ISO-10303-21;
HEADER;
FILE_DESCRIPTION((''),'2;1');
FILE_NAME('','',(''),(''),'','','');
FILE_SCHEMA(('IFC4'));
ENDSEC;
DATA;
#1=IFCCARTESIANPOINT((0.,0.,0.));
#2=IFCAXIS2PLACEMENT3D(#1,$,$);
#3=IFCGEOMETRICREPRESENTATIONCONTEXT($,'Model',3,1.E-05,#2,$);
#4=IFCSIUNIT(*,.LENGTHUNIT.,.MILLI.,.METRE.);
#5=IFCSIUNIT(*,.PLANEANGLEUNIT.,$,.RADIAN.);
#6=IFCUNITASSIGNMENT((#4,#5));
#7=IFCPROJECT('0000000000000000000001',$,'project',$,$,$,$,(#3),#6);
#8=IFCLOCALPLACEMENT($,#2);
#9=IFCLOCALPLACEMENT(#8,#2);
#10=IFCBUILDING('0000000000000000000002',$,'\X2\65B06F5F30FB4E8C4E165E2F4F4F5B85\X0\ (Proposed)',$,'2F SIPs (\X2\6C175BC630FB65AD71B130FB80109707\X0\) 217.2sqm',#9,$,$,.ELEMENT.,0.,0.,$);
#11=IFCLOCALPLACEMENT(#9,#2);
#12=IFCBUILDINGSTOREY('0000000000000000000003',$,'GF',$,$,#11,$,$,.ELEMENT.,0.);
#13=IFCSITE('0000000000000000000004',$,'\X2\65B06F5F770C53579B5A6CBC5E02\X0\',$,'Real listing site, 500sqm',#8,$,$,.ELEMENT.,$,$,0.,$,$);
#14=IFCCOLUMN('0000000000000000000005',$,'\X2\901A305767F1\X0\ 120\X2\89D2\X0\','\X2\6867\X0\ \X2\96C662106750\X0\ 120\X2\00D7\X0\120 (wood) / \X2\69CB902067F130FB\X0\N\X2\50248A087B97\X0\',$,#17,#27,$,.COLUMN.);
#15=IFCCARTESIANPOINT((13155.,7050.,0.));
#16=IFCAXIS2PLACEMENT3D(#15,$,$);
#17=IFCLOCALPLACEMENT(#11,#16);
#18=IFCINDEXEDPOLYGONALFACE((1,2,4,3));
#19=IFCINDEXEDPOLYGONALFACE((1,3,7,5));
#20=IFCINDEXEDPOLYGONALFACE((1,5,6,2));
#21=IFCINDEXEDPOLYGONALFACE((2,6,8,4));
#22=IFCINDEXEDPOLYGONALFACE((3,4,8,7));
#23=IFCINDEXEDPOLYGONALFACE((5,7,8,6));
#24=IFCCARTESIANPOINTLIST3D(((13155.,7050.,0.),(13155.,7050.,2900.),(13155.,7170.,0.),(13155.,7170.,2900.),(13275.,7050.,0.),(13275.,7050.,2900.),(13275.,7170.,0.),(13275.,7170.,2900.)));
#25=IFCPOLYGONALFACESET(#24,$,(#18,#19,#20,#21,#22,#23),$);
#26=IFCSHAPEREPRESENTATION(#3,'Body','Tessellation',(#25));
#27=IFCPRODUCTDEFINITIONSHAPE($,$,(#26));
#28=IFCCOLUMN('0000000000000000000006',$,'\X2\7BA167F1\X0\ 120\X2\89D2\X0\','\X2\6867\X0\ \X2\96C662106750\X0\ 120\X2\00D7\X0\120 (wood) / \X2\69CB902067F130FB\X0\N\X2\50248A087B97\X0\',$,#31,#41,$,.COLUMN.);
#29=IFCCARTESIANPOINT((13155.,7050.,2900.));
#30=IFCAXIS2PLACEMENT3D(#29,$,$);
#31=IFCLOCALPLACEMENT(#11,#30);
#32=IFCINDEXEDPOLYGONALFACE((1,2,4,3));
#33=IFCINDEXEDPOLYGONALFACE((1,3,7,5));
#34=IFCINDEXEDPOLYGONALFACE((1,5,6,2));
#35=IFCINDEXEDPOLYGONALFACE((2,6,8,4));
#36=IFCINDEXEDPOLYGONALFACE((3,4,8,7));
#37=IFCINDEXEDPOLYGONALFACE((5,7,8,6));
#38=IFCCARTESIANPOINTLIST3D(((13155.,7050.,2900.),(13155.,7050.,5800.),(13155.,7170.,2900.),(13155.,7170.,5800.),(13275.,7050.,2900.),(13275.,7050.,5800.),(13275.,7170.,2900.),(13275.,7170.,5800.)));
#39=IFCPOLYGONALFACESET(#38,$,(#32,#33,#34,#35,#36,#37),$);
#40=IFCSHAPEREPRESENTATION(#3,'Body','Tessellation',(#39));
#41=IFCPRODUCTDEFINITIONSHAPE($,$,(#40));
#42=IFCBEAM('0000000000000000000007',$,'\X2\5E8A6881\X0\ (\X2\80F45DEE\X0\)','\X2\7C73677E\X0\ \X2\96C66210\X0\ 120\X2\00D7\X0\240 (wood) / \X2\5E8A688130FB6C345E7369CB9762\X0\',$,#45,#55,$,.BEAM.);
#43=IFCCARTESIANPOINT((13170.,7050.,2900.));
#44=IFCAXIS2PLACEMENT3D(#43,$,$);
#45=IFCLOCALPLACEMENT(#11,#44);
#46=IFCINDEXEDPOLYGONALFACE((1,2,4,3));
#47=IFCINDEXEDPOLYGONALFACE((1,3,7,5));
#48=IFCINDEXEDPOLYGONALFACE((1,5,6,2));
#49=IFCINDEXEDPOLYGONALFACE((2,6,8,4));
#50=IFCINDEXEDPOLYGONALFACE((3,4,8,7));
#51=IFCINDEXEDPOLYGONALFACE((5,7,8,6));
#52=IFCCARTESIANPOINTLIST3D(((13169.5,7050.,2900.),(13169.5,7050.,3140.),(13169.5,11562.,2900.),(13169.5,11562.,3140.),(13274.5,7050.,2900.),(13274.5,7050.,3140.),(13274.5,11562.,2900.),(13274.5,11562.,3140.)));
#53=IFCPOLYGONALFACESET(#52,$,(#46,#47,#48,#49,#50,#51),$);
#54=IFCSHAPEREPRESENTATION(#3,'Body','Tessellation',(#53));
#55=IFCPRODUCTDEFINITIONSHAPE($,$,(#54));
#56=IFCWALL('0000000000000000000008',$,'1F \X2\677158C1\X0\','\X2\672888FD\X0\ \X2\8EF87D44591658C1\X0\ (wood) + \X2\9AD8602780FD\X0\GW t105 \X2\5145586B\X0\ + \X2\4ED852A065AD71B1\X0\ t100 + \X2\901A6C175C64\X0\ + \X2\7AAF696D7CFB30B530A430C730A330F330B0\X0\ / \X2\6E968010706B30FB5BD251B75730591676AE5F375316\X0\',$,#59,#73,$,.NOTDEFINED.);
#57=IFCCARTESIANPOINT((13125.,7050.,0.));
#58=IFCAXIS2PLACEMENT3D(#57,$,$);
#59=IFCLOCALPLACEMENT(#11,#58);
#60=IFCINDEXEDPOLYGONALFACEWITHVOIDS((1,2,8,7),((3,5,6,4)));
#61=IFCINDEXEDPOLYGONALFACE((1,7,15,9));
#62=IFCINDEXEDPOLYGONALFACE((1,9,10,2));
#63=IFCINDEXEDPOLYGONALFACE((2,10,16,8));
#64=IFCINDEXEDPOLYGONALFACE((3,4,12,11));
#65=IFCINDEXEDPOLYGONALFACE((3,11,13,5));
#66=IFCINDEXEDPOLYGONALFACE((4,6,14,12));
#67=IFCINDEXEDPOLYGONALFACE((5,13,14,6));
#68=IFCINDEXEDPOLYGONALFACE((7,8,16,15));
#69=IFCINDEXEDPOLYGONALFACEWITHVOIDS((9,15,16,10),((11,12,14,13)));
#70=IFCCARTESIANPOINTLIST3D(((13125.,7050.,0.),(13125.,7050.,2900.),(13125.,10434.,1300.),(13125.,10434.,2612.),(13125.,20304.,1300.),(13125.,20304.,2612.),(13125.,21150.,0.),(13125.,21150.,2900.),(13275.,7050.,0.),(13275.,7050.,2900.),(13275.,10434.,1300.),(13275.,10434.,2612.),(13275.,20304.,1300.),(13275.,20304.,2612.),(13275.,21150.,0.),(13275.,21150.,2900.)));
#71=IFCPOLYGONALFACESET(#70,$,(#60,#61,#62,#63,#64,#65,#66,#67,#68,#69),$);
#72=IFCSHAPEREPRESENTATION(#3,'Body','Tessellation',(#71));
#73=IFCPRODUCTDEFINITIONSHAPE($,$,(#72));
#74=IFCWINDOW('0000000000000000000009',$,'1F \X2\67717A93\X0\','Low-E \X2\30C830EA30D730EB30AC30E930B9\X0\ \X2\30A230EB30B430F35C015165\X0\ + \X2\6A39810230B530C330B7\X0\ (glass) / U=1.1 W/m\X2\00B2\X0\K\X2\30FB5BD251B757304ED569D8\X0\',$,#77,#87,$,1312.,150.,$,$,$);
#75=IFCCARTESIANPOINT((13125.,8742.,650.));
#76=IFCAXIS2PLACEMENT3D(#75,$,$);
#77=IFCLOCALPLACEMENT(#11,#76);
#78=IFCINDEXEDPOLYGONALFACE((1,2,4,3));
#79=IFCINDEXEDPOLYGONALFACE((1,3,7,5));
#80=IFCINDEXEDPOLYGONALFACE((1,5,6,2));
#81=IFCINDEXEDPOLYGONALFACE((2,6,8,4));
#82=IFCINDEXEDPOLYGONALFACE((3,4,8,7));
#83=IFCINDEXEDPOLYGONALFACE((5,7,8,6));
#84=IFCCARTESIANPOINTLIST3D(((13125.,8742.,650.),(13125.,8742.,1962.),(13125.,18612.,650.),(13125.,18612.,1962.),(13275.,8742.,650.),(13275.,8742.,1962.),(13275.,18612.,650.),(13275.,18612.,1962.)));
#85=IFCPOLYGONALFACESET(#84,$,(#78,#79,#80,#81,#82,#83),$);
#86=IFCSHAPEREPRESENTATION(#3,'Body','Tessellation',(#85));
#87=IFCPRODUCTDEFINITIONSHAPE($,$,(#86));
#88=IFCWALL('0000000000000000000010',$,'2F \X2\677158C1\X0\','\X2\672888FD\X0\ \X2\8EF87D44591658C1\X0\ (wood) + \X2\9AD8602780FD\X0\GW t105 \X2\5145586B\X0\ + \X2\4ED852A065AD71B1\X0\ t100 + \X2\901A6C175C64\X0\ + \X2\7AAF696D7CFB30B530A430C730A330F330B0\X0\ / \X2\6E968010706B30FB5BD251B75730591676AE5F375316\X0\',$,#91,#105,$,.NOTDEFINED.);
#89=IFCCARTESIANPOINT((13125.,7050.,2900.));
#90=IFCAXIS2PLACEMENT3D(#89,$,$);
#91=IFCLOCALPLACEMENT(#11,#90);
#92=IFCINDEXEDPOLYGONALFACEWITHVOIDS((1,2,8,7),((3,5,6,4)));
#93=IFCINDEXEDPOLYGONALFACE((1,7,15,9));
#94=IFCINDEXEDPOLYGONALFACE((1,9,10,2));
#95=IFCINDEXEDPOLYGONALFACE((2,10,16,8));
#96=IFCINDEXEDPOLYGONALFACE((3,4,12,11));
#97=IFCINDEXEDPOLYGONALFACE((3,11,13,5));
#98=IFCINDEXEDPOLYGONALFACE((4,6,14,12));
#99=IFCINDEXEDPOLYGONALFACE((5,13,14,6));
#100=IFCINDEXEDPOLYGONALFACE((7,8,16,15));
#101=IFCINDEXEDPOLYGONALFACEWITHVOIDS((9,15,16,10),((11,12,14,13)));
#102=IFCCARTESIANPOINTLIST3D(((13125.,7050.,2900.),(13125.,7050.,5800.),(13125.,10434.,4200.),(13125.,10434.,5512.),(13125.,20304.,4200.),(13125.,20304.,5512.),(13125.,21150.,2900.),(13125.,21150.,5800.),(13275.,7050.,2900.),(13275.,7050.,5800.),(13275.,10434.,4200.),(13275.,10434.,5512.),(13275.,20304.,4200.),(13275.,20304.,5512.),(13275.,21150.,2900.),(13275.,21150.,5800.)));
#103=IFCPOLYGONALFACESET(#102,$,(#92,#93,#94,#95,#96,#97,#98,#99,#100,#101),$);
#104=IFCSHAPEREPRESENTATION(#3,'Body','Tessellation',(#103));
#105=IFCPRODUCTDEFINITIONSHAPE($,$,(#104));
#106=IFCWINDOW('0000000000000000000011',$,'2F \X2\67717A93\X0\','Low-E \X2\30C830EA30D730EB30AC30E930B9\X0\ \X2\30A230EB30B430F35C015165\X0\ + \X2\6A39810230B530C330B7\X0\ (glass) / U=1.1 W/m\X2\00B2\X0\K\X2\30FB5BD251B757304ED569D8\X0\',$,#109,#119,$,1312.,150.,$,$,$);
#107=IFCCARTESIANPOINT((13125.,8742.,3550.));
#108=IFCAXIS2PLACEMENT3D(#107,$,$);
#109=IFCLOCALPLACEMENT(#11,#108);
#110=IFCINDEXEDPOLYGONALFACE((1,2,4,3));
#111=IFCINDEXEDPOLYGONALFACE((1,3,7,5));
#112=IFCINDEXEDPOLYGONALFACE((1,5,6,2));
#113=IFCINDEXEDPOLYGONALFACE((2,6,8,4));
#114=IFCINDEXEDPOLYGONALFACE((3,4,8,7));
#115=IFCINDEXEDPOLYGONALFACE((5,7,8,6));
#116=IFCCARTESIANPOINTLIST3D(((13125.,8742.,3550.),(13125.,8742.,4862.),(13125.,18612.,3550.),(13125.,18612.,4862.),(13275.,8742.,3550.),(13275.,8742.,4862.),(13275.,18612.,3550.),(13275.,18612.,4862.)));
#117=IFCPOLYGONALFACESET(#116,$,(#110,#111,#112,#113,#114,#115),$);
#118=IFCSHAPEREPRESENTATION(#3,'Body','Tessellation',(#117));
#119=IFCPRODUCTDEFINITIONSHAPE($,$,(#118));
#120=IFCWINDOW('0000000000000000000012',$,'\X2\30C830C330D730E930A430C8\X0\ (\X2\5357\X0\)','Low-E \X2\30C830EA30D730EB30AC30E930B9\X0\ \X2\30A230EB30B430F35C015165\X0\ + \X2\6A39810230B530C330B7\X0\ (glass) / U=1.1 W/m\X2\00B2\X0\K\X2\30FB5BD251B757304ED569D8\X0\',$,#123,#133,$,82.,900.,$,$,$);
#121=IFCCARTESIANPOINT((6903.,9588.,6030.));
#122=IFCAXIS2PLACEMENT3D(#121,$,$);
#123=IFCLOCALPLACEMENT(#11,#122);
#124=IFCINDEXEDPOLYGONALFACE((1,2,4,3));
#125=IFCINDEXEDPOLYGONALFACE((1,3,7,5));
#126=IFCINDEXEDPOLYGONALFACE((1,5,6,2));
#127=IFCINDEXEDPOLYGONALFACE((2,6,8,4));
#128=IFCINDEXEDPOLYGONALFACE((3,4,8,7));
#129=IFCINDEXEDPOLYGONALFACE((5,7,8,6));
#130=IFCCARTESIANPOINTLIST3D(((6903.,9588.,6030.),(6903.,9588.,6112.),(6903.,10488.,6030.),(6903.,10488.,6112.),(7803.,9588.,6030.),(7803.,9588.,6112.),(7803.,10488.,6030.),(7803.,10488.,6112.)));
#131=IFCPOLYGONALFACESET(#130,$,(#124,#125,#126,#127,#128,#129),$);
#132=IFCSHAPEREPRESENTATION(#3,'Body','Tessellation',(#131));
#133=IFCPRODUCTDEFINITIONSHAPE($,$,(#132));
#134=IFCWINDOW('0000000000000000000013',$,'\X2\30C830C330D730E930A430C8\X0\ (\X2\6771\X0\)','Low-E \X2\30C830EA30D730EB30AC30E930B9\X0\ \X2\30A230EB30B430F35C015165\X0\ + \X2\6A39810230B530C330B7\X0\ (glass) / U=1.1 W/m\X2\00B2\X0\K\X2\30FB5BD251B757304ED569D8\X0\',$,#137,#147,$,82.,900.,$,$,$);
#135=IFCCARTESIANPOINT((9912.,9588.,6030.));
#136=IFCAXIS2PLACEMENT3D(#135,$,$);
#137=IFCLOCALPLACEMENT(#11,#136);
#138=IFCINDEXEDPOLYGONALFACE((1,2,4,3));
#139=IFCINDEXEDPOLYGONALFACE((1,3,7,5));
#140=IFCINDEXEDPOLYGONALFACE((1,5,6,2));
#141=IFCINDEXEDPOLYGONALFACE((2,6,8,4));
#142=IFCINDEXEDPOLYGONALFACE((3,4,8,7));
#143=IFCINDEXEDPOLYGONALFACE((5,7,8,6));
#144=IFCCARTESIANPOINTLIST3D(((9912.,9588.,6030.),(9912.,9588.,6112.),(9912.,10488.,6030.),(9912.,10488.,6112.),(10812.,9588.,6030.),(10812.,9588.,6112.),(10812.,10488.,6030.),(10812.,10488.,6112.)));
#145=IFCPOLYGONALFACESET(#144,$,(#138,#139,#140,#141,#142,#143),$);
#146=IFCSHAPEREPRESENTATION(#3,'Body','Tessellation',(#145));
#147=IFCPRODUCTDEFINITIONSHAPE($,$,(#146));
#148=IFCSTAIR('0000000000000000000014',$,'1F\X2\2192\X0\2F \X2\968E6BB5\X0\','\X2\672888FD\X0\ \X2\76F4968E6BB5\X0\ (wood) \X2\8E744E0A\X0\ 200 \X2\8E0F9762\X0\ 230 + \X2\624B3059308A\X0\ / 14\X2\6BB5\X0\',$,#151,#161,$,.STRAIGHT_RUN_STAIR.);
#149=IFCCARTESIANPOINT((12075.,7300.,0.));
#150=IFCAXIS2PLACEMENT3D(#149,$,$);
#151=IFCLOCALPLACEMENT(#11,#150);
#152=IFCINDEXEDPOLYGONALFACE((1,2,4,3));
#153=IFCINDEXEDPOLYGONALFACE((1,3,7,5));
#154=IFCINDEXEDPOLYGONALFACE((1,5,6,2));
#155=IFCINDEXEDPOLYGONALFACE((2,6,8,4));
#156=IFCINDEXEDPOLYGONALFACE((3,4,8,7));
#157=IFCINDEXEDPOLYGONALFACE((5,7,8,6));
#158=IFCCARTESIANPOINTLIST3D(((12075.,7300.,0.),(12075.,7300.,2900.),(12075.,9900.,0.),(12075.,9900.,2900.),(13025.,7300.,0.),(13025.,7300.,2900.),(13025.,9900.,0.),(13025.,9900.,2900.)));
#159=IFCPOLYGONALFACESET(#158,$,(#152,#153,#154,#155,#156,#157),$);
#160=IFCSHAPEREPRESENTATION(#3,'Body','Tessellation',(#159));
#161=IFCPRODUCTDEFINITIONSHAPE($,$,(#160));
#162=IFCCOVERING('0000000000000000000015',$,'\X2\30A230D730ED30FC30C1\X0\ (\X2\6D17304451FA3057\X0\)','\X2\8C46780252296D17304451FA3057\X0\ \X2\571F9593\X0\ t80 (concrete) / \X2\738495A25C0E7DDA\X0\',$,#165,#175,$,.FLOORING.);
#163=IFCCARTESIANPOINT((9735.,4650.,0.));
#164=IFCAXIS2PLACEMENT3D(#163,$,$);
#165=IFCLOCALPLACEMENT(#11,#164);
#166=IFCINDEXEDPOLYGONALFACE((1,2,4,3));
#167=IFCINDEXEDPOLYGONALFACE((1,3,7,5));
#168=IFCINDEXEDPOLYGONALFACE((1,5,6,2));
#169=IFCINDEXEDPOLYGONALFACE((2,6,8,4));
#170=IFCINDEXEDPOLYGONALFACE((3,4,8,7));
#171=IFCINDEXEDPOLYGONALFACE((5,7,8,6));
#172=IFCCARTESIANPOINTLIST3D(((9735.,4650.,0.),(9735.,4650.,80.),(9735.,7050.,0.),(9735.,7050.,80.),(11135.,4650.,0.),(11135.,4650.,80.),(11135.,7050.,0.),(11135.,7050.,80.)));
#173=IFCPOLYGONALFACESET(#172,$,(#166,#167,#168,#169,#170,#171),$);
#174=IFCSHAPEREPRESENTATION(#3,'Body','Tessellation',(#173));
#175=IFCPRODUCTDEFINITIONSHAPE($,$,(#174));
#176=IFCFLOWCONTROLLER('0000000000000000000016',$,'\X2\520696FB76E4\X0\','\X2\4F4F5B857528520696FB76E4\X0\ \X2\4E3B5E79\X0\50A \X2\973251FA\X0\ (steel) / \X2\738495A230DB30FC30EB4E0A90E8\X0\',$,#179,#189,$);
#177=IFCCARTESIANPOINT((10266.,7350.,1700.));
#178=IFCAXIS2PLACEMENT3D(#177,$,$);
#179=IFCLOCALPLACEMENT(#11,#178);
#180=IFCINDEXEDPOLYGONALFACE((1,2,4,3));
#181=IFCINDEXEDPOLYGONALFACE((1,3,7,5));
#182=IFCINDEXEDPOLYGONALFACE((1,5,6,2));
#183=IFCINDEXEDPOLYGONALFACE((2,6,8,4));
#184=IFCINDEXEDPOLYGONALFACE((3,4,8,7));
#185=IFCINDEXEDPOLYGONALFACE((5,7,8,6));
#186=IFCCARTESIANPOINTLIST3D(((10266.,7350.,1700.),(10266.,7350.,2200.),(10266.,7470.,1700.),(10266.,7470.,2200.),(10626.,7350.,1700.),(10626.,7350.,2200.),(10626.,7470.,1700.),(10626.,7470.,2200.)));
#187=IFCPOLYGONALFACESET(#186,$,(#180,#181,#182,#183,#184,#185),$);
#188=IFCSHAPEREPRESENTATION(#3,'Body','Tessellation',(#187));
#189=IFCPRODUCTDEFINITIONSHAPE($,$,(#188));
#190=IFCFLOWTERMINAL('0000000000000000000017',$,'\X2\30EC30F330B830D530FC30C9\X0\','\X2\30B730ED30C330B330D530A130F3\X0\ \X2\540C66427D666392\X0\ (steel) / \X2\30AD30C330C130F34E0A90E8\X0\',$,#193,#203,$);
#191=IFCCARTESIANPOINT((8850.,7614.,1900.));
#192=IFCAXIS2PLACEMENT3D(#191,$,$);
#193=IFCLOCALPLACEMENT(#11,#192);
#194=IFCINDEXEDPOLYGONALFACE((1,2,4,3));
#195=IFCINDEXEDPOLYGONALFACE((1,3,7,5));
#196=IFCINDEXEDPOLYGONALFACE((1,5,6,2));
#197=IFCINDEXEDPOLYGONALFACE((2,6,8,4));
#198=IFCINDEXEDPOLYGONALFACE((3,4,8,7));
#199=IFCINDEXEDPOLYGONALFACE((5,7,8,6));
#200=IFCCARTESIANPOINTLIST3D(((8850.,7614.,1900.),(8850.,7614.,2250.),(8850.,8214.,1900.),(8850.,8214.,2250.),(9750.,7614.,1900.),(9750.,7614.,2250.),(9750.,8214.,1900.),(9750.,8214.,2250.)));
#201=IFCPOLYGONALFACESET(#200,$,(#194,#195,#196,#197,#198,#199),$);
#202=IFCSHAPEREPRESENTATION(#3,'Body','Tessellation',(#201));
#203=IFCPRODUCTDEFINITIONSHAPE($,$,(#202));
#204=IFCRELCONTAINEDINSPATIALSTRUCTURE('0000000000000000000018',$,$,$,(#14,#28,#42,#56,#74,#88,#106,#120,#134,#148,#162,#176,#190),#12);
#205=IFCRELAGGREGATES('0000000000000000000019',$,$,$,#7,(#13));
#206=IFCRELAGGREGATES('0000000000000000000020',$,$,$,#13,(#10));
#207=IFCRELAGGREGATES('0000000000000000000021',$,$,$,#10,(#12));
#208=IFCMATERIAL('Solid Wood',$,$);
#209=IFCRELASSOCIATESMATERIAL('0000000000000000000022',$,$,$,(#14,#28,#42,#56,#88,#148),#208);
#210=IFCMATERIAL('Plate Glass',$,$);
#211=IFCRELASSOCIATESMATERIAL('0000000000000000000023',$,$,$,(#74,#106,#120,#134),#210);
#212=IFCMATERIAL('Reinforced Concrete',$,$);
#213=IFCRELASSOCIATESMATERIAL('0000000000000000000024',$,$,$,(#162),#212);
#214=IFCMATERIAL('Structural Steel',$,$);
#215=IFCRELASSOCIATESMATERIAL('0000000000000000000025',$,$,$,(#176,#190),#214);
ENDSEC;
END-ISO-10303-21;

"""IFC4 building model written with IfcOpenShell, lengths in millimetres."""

from ifc_helpers import new_model, si_unit, frame, frame_2d, origin, place, context, project, spatial, rectangle, extrude, material, element, fill, save


model = new_model("IFC4")

# Units and contexts
model_context = context("Model", 3, precision=1e-05, world=origin())
ifc_project = project(units=[si_unit("LENGTHUNIT", "METRE", prefix="MILLI"), si_unit("PLANEANGLEUNIT", "RADIAN")], contexts=[model_context])

# Site, building, storey
site_placement = place(None, origin())
site = spatial("IfcSite", under=ifc_project, at=site_placement, Name="新潟県南魚沼市", ObjectType="Real listing site, 500sqm", CompositionType="ELEMENT", RefElevation=0.0)
building_placement = place(site_placement, origin())
building = spatial("IfcBuilding", under=site, at=building_placement, Name="新潟・二世帯住宅 (Proposed)", ObjectType="2F SIPs (気密・断熱・耐震) 217.2sqm", CompositionType="ELEMENT", ElevationOfRefHeight=0.0, ElevationOfTerrain=0.0)
storey_placement = place(building_placement, origin())
storey = spatial("IfcBuildingStorey", under=building, at=storey_placement, Name="GF", CompositionType="ELEMENT", Elevation=0.0)

# Columns
ifc_material_1 = material(Name="Solid Wood")
column_1_placement = place(storey_placement, frame((13155.0, 7050.0, 0.0)))
element("IfcColumn", 1, at=column_1_placement, inside=storey, material=ifc_material_1, Name="通し柱 120角", Description="桧 集成材 120×120 (wood) / 構造柱・N値計算", PredefinedType="COLUMN", context=model_context, shape_type="SweptSolid", body=[
    extrude(rectangle(XDim=120.0, YDim=120.0, at=frame_2d((60.0, 60.0))), frame((13155.0, 7050.0, 0.0)), (0.0, 0.0, 1.0), 2900.0),
])
column_2_placement = place(storey_placement, frame((13155.0, 7050.0, 2900.0)))
element("IfcColumn", 2, at=column_2_placement, inside=storey, material=ifc_material_1, Name="管柱 120角", Description="桧 集成材 120×120 (wood) / 構造柱・N値計算", PredefinedType="COLUMN", context=model_context, shape_type="SweptSolid", body=[
    extrude(rectangle(XDim=120.0, YDim=120.0, at=frame_2d((60.0, 60.0))), frame((13155.0, 7050.0, 2900.0)), (0.0, 0.0, 1.0), 2900.0),
])

# Beam
beam_1_placement = place(storey_placement, frame((13170.0, 7050.0, 2900.0)))
element("IfcBeam", 3, at=beam_1_placement, inside=storey, material=ifc_material_1, Name="床梁 (胴差)", Description="米松 集成 120×240 (wood) / 床梁・水平構面", PredefinedType="BEAM", context=model_context, shape_type="SweptSolid", body=[
    extrude(rectangle(XDim=105.0, YDim=4512.0, at=frame_2d((52.0, 2256.0))), frame((13170.0, 7050.0, 2900.0)), (0.0, 0.0, 1.0), 240.0),
])

# Wall, opening, window
wall_1_placement = place(storey_placement, frame((13125.0, 7050.0, 0.0)))
wall_1 = element("IfcWall", 4, at=wall_1_placement, inside=storey, material=ifc_material_1, Name="1F 東壁", Description="木製 軸組外壁 (wood) + 高性能GW t105 充填 + 付加断熱 t100 + 通気層 + 窯業系サイディング / 準耐火・寒冷地外皮強化", PredefinedType="NOTDEFINED", context=model_context, shape_type="SweptSolid", body=[
    extrude(rectangle(XDim=150.0, YDim=14100.0, at=frame_2d((75.0, 7050.0))), frame((13125.0, 7050.0, 0.0)), (0.0, 0.0, 1.0), 2900.0),
])
opening_1_placement = place(storey_placement, frame((13125.0, 8742.0, 650.0)))
opening_1 = element("IfcOpeningElement", 5, at=opening_1_placement, cuts=wall_1, PredefinedType="NOTDEFINED", context=model_context, shape_type="SweptSolid", body=[
    extrude(rectangle(XDim=150.0, YDim=9870.0, at=frame_2d((75.0, 4935.0))), frame((13125.0, 8742.0, 650.0)), (0.0, 0.0, 1.0), 1312.0),
])
ifc_material_2 = material(Name="Plate Glass")
window_1_placement = place(storey_placement, frame((13125.0, 8742.0, 650.0)))
window_1 = element("IfcWindow", 6, at=window_1_placement, inside=storey, material=ifc_material_2, Name="1F 東窓", Description="Low-E トリプルガラス アルゴン封入 + 樹脂サッシ (glass) / U=1.1 W/m²K・寒冷地仕様", OverallHeight=1312.0, OverallWidth=150.0, context=model_context, shape_type="SweptSolid", body=[
    extrude(rectangle(XDim=150.0, YDim=9870.0, at=frame_2d((75.0, 4935.0))), frame((13125.0, 8742.0, 650.0)), (0.0, 0.0, 1.0), 1312.0),
])
fill(opening_1, window_1)

# Wall, opening, window
wall_2_placement = place(storey_placement, frame((13125.0, 7050.0, 2900.0)))
wall_2 = element("IfcWall", 7, at=wall_2_placement, inside=storey, material=ifc_material_1, Name="2F 東壁", Description="木製 軸組外壁 (wood) + 高性能GW t105 充填 + 付加断熱 t100 + 通気層 + 窯業系サイディング / 準耐火・寒冷地外皮強化", PredefinedType="NOTDEFINED", context=model_context, shape_type="SweptSolid", body=[
    extrude(rectangle(XDim=150.0, YDim=14100.0, at=frame_2d((75.0, 7050.0))), frame((13125.0, 7050.0, 2900.0)), (0.0, 0.0, 1.0), 2900.0),
])
opening_2_placement = place(storey_placement, frame((13125.0, 8742.0, 3550.0)))
opening_2 = element("IfcOpeningElement", 8, at=opening_2_placement, cuts=wall_2, PredefinedType="NOTDEFINED", context=model_context, shape_type="SweptSolid", body=[
    extrude(rectangle(XDim=150.0, YDim=9870.0, at=frame_2d((75.0, 4935.0))), frame((13125.0, 8742.0, 3550.0)), (0.0, 0.0, 1.0), 1312.0),
])
window_2_placement = place(storey_placement, frame((13125.0, 8742.0, 3550.0)))
window_2 = element("IfcWindow", 9, at=window_2_placement, inside=storey, material=ifc_material_2, Name="2F 東窓", Description="Low-E トリプルガラス アルゴン封入 + 樹脂サッシ (glass) / U=1.1 W/m²K・寒冷地仕様", OverallHeight=1312.0, OverallWidth=150.0, context=model_context, shape_type="SweptSolid", body=[
    extrude(rectangle(XDim=150.0, YDim=9870.0, at=frame_2d((75.0, 4935.0))), frame((13125.0, 8742.0, 3550.0)), (0.0, 0.0, 1.0), 1312.0),
])
fill(opening_2, window_2)

# Windows
window_3_placement = place(storey_placement, frame((6903.0, 9588.0, 6030.0)))
element("IfcWindow", 10, at=window_3_placement, inside=storey, material=ifc_material_2, Name="トップライト (南)", Description="Low-E トリプルガラス アルゴン封入 + 樹脂サッシ (glass) / U=1.1 W/m²K・寒冷地仕様", OverallHeight=82.0, OverallWidth=900.0, context=model_context, shape_type="SweptSolid", body=[
    extrude(rectangle(XDim=900.0, YDim=900.0, at=frame_2d((450.0, 450.0))), frame((6903.0, 9588.0, 6030.0)), (0.0, 0.0, 1.0), 82.0),
])
window_4_placement = place(storey_placement, frame((9912.0, 9588.0, 6030.0)))
element("IfcWindow", 11, at=window_4_placement, inside=storey, material=ifc_material_2, Name="トップライト (東)", Description="Low-E トリプルガラス アルゴン封入 + 樹脂サッシ (glass) / U=1.1 W/m²K・寒冷地仕様", OverallHeight=82.0, OverallWidth=900.0, context=model_context, shape_type="SweptSolid", body=[
    extrude(rectangle(XDim=900.0, YDim=900.0, at=frame_2d((450.0, 450.0))), frame((9912.0, 9588.0, 6030.0)), (0.0, 0.0, 1.0), 82.0),
])

# Stair
stair_placement = place(storey_placement, frame((12075.0, 7300.0, 0.0)))
element("IfcStair", 12, at=stair_placement, inside=storey, material=ifc_material_1, Name="1F→2F 階段", Description="木製 直階段 (wood) 蹴上 200 踏面 230 + 手すり / 14段", PredefinedType="STRAIGHT_RUN_STAIR", context=model_context, shape_type="SweptSolid", body=[
    extrude(rectangle(XDim=950.0, YDim=2600.0, at=frame_2d((475.0, 1300.0))), frame((12075.0, 7300.0, 0.0)), (0.0, 0.0, 1.0), 2900.0),
])

# Covering
ifc_material_3 = material(Name="Reinforced Concrete")
covering_placement = place(storey_placement, frame((9735.0, 4650.0, 0.0)))
element("IfcCovering", 13, at=covering_placement, inside=storey, material=ifc_material_3, Name="アプローチ (洗い出し)", Description="豆砂利洗い出し 土間 t80 (concrete) / 玄関導線", PredefinedType="FLOORING", context=model_context, shape_type="SweptSolid", body=[
    extrude(rectangle(XDim=1400.0, YDim=2400.0, at=frame_2d((700.0, 1200.0))), frame((9735.0, 4650.0, 0.0)), (0.0, 0.0, 1.0), 80.0),
])

# Flow controller
ifc_material_4 = material(Name="Structural Steel")
flow_controller_placement = place(storey_placement, frame((10266.0, 7350.0, 1700.0)))
element("IfcFlowController", 14, at=flow_controller_placement, inside=storey, material=ifc_material_4, Name="分電盤", Description="住宅用分電盤 主幹50A 露出 (steel) / 玄関ホール上部", context=model_context, shape_type="SweptSolid", body=[
    extrude(rectangle(XDim=360.0, YDim=120.0, at=frame_2d((180.0, 60.0))), frame((10266.0, 7350.0, 1700.0)), (0.0, 0.0, 1.0), 500.0),
])

# Flow terminal
flow_terminal_1_placement = place(storey_placement, frame((8850.0, 7614.0, 1900.0)))
element("IfcFlowTerminal", 15, at=flow_terminal_1_placement, inside=storey, material=ifc_material_4, Name="レンジフード", Description="シロッコファン 同時給排 (steel) / キッチン上部", context=model_context, shape_type="SweptSolid", body=[
    extrude(rectangle(XDim=900.0, YDim=600.0, at=frame_2d((450.0, 300.0))), frame((8850.0, 7614.0, 1900.0)), (0.0, 0.0, 1.0), 350.0),
])

save(model, "model.ifc")
